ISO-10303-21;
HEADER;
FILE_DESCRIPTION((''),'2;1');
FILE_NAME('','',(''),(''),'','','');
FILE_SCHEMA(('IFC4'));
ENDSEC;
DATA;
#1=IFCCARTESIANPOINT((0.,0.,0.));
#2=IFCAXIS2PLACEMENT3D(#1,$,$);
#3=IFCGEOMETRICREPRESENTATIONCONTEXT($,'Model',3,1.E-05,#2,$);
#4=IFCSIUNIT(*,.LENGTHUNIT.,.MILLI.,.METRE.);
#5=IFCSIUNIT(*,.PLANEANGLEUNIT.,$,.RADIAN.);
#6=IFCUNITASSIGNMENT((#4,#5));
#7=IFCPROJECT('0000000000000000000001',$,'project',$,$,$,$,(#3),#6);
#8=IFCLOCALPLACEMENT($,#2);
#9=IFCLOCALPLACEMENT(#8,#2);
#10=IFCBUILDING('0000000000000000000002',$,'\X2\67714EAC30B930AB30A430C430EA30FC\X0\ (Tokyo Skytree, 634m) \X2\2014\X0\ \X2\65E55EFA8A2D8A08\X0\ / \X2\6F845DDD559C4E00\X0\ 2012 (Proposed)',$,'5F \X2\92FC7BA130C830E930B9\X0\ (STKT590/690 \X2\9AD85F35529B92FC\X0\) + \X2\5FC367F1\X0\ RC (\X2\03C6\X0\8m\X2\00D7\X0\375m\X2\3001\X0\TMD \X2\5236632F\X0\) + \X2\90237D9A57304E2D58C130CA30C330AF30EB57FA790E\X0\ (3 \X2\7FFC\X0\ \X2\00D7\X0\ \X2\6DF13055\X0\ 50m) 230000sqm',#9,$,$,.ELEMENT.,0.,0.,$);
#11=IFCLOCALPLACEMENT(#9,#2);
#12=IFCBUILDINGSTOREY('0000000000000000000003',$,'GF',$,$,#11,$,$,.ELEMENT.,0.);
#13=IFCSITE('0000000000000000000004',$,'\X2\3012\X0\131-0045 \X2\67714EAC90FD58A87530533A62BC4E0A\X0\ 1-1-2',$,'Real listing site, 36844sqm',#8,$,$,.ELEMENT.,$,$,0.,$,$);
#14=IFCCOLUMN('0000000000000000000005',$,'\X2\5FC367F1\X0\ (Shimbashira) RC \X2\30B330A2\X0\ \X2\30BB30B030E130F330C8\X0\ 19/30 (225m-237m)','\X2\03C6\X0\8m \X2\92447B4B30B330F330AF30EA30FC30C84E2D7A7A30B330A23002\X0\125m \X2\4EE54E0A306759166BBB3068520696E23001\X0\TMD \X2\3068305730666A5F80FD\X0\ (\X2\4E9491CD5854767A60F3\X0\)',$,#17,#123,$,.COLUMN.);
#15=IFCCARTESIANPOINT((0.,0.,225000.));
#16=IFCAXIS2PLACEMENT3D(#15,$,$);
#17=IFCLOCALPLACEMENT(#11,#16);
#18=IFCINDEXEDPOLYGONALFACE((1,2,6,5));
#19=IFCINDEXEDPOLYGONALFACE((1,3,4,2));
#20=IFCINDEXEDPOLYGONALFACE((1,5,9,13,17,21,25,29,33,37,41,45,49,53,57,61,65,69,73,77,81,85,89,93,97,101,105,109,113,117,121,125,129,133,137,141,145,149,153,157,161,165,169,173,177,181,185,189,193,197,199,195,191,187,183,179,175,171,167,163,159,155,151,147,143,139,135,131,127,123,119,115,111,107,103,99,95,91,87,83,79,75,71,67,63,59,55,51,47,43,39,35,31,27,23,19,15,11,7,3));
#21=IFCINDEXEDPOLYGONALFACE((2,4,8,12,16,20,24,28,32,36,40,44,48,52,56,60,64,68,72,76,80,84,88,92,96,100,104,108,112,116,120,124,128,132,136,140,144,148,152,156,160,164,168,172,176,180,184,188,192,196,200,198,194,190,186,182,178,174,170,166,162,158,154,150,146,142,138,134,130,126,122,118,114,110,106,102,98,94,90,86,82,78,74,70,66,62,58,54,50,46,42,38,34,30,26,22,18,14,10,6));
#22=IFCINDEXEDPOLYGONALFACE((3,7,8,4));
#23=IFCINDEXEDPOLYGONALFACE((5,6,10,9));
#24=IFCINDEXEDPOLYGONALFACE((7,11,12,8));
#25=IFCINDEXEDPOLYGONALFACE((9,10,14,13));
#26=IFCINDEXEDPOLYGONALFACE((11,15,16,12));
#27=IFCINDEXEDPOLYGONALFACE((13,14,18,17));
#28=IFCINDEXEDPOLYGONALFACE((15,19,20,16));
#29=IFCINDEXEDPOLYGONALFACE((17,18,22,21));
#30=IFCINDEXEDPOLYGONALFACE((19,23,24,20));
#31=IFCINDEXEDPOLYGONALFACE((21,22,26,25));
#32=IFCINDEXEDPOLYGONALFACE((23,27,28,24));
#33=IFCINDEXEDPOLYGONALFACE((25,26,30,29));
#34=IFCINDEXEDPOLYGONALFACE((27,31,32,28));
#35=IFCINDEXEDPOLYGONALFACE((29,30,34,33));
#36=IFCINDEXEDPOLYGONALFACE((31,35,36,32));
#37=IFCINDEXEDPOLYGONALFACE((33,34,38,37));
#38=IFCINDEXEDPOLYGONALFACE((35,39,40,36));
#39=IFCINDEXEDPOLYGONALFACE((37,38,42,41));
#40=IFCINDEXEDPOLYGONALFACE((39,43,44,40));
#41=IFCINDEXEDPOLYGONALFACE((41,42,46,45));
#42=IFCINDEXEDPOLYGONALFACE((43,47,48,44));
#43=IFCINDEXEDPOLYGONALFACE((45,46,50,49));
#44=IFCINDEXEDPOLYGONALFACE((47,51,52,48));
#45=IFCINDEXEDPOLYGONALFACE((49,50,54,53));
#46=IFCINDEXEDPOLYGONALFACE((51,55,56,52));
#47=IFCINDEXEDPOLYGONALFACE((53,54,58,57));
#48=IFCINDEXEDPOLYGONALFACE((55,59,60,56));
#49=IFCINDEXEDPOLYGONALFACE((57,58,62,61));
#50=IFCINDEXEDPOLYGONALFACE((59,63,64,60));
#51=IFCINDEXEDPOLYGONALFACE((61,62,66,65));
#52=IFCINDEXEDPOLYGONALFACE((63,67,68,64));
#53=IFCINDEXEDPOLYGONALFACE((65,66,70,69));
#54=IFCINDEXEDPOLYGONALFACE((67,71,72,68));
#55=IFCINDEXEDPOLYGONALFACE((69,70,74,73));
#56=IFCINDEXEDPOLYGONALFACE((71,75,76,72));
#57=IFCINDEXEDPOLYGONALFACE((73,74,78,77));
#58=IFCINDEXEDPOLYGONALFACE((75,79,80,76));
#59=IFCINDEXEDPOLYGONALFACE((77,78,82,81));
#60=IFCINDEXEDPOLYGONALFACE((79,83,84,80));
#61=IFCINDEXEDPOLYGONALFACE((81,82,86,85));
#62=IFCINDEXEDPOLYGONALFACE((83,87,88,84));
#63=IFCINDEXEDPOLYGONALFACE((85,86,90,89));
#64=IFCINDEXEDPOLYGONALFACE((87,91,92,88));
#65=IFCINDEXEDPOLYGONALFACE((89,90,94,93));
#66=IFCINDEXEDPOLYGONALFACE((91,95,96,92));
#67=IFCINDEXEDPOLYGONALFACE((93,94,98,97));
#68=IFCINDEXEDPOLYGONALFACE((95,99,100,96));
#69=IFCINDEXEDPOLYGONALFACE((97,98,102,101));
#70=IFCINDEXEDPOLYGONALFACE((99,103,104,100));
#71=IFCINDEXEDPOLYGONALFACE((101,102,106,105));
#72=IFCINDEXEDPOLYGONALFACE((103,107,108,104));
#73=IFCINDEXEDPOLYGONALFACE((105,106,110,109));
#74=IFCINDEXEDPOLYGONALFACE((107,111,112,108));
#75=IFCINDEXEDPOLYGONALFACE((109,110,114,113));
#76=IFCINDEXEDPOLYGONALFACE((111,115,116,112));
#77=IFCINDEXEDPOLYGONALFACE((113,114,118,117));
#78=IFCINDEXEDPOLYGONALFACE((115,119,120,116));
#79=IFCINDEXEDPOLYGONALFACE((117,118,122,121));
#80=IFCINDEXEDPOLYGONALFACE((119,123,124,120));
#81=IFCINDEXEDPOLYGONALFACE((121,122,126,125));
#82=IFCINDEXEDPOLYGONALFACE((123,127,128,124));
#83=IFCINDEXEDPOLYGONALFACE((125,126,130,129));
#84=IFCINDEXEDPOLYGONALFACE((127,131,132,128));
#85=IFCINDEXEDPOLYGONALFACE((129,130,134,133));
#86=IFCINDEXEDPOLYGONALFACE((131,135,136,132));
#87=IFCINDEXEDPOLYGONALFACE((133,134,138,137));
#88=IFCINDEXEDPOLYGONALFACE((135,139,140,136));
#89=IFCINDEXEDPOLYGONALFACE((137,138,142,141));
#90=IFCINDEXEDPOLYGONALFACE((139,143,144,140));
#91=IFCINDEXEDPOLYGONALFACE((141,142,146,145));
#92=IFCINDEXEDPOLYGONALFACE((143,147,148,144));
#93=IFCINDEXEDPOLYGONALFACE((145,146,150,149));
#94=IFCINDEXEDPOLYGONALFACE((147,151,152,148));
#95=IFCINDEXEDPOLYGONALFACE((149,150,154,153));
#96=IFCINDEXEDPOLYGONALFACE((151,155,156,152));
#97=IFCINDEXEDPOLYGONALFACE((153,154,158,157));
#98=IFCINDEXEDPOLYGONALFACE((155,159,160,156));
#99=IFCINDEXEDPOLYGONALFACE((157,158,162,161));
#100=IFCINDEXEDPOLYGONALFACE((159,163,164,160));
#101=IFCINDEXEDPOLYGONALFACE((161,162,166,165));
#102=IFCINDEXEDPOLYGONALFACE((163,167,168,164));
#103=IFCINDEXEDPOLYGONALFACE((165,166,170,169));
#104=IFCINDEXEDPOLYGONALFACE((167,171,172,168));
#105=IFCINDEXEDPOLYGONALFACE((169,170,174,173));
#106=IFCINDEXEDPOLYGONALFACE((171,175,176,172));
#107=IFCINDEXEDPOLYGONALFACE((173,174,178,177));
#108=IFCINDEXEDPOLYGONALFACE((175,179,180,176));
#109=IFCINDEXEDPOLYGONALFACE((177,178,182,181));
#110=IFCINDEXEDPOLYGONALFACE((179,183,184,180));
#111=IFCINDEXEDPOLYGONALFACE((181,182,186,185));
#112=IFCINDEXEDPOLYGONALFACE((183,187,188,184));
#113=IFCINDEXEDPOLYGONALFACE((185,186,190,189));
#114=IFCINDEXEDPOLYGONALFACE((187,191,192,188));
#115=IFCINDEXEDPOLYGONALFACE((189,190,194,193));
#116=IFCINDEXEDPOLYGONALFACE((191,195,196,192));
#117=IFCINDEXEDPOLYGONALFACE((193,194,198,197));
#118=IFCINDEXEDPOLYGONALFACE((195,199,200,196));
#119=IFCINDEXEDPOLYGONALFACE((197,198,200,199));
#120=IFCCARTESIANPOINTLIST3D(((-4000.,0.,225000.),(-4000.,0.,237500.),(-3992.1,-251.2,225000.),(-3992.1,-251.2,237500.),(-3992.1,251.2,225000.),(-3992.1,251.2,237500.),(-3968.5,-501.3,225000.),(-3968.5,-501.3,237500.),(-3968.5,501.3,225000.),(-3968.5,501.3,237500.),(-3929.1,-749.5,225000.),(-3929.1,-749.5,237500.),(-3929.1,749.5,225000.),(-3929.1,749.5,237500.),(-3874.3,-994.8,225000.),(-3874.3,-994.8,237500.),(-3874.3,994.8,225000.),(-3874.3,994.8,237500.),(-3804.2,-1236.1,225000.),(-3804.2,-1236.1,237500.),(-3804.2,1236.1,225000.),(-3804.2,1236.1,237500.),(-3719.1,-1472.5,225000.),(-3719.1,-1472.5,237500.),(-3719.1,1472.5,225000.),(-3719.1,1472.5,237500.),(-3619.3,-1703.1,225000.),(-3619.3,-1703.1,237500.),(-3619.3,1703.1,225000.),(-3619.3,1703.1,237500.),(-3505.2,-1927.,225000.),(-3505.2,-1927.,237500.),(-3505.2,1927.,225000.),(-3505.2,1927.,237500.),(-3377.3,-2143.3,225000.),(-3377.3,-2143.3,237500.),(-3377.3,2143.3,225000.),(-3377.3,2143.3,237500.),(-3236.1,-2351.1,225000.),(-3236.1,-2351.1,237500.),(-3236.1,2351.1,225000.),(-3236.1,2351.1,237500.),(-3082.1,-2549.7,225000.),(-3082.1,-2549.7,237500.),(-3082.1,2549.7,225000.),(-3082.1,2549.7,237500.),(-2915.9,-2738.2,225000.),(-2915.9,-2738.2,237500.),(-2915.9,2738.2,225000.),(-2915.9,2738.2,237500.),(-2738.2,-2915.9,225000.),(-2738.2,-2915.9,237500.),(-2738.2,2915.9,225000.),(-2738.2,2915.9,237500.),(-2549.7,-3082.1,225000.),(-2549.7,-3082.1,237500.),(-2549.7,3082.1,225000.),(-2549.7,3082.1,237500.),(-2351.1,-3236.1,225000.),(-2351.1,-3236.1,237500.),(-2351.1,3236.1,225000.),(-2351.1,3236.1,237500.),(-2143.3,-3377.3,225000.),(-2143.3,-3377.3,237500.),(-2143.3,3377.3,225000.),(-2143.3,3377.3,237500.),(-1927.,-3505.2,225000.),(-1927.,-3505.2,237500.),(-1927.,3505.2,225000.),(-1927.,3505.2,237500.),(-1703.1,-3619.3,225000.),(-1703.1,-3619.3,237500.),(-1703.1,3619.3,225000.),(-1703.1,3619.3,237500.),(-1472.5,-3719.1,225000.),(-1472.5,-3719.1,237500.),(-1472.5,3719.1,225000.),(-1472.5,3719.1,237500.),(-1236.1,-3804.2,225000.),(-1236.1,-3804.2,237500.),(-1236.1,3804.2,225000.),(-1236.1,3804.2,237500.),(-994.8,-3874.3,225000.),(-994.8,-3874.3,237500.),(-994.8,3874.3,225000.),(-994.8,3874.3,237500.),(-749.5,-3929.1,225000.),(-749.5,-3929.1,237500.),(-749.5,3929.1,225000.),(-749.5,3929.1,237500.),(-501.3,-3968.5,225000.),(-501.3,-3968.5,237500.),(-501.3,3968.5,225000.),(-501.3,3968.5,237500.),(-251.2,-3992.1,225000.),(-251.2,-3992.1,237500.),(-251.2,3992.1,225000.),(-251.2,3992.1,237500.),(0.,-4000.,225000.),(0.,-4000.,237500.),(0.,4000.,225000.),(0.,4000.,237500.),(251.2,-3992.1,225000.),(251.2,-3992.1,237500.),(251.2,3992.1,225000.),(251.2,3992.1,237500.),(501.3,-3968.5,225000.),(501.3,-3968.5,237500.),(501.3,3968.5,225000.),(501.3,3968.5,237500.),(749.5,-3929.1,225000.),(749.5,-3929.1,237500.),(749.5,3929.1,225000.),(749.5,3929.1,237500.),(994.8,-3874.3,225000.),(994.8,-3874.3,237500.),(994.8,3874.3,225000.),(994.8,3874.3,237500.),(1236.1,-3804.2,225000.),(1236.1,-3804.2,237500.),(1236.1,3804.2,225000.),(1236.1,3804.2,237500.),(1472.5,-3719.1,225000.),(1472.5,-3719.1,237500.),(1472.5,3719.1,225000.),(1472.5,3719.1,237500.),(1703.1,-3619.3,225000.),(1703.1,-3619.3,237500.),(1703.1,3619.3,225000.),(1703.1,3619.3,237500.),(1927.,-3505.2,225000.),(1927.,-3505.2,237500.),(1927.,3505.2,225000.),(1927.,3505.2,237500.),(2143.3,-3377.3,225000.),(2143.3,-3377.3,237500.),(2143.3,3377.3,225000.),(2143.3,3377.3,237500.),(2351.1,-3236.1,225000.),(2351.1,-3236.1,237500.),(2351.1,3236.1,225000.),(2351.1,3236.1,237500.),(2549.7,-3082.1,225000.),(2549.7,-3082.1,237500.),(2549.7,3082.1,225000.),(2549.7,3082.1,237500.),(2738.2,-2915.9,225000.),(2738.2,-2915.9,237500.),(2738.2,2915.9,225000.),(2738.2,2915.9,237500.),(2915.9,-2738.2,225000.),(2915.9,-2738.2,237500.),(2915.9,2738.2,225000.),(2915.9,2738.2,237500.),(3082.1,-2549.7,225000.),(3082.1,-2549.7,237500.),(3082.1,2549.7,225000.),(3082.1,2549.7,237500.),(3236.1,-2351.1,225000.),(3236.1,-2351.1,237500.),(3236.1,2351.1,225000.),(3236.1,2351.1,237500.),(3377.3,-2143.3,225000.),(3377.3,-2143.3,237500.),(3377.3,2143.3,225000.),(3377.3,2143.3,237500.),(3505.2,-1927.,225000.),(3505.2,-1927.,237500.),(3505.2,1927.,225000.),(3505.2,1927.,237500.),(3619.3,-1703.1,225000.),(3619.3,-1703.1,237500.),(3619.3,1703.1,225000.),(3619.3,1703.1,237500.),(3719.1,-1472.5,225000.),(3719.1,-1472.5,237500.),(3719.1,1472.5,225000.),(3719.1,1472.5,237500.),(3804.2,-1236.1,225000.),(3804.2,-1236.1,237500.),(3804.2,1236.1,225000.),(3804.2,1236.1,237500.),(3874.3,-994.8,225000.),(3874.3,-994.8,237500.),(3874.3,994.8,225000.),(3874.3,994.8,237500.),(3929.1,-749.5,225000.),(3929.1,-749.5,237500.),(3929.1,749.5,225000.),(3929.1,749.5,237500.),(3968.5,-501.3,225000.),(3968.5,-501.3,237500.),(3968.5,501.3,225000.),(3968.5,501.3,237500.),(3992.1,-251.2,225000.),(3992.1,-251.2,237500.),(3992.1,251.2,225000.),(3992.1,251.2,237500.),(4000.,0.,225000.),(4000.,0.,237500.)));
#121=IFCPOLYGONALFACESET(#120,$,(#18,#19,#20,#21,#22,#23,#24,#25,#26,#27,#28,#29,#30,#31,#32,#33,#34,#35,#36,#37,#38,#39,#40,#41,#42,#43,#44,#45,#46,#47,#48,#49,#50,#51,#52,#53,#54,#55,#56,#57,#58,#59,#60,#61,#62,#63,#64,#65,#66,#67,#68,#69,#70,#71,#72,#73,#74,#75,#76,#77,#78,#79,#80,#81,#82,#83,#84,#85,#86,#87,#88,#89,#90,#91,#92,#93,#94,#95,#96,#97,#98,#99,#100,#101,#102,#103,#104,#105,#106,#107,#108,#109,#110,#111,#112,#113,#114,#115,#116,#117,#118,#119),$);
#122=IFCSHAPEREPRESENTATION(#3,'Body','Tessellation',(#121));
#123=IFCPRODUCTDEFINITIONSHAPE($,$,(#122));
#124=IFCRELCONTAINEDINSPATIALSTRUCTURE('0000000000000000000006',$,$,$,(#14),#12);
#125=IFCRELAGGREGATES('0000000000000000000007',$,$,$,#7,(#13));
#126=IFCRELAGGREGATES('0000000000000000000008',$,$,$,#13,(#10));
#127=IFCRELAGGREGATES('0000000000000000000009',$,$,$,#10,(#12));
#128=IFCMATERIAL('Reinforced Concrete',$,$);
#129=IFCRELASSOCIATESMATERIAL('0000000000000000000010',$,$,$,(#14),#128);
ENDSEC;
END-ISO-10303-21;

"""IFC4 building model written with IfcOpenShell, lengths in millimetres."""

from ifc_helpers import new_model, si_unit, frame, origin, origin_2d, place, context, project, spatial, circle, extrude, material, element, save


model = new_model("IFC4")

# Units and contexts
model_context = context("Model", 3, precision=1e-05, world=origin())
ifc_project = project(units=[si_unit("LENGTHUNIT", "METRE", prefix="MILLI"), si_unit("PLANEANGLEUNIT", "RADIAN")], contexts=[model_context])

# Site, building, storey
site_placement = place(None, origin())
site = spatial("IfcSite", under=ifc_project, at=site_placement, Name="〒131-0045 東京都墨田区押上 1-1-2", ObjectType="Real listing site, 36844sqm", CompositionType="ELEMENT", RefElevation=0.0)
building_placement = place(site_placement, origin())
building = spatial("IfcBuilding", under=site, at=building_placement, Name="東京スカイツリー (Tokyo Skytree, 634m) — 日建設計 / 澄川喜一 2012 (Proposed)", ObjectType="5F 鋼管トラス (STKT590/690 高張力鋼) + 心柱 RC (φ8m×375m、TMD 制振) + 連続地中壁ナックル基礎 (3 翼 × 深さ 50m) 230000sqm", CompositionType="ELEMENT", ElevationOfRefHeight=0.0, ElevationOfTerrain=0.0)
storey_placement = place(building_placement, origin())
storey = spatial("IfcBuildingStorey", under=building, at=storey_placement, Name="GF", CompositionType="ELEMENT", Elevation=0.0)

# Column
ifc_material_1 = material(Name="Reinforced Concrete")
column_1_placement = place(storey_placement, frame((0.0, 0.0, 225000.0)))
element("IfcColumn", 1, at=column_1_placement, inside=storey, material=ifc_material_1, Name="心柱 (Shimbashira) RC コア セグメント 19/30 (225m-237m)", Description="φ8m 鉄筋コンクリート中空コア。125m 以上で外殻と分離、TMD として機能 (五重塔発想)", PredefinedType="COLUMN", context=model_context, shape_type="SweptSolid", body=[
    extrude(circle(Radius=4000.0, at=origin_2d()), frame((0.0, 0.0, 225000.0)), (0.0, 0.0, 1.0), 12500.0),
])

save(model, "model.ifc")
